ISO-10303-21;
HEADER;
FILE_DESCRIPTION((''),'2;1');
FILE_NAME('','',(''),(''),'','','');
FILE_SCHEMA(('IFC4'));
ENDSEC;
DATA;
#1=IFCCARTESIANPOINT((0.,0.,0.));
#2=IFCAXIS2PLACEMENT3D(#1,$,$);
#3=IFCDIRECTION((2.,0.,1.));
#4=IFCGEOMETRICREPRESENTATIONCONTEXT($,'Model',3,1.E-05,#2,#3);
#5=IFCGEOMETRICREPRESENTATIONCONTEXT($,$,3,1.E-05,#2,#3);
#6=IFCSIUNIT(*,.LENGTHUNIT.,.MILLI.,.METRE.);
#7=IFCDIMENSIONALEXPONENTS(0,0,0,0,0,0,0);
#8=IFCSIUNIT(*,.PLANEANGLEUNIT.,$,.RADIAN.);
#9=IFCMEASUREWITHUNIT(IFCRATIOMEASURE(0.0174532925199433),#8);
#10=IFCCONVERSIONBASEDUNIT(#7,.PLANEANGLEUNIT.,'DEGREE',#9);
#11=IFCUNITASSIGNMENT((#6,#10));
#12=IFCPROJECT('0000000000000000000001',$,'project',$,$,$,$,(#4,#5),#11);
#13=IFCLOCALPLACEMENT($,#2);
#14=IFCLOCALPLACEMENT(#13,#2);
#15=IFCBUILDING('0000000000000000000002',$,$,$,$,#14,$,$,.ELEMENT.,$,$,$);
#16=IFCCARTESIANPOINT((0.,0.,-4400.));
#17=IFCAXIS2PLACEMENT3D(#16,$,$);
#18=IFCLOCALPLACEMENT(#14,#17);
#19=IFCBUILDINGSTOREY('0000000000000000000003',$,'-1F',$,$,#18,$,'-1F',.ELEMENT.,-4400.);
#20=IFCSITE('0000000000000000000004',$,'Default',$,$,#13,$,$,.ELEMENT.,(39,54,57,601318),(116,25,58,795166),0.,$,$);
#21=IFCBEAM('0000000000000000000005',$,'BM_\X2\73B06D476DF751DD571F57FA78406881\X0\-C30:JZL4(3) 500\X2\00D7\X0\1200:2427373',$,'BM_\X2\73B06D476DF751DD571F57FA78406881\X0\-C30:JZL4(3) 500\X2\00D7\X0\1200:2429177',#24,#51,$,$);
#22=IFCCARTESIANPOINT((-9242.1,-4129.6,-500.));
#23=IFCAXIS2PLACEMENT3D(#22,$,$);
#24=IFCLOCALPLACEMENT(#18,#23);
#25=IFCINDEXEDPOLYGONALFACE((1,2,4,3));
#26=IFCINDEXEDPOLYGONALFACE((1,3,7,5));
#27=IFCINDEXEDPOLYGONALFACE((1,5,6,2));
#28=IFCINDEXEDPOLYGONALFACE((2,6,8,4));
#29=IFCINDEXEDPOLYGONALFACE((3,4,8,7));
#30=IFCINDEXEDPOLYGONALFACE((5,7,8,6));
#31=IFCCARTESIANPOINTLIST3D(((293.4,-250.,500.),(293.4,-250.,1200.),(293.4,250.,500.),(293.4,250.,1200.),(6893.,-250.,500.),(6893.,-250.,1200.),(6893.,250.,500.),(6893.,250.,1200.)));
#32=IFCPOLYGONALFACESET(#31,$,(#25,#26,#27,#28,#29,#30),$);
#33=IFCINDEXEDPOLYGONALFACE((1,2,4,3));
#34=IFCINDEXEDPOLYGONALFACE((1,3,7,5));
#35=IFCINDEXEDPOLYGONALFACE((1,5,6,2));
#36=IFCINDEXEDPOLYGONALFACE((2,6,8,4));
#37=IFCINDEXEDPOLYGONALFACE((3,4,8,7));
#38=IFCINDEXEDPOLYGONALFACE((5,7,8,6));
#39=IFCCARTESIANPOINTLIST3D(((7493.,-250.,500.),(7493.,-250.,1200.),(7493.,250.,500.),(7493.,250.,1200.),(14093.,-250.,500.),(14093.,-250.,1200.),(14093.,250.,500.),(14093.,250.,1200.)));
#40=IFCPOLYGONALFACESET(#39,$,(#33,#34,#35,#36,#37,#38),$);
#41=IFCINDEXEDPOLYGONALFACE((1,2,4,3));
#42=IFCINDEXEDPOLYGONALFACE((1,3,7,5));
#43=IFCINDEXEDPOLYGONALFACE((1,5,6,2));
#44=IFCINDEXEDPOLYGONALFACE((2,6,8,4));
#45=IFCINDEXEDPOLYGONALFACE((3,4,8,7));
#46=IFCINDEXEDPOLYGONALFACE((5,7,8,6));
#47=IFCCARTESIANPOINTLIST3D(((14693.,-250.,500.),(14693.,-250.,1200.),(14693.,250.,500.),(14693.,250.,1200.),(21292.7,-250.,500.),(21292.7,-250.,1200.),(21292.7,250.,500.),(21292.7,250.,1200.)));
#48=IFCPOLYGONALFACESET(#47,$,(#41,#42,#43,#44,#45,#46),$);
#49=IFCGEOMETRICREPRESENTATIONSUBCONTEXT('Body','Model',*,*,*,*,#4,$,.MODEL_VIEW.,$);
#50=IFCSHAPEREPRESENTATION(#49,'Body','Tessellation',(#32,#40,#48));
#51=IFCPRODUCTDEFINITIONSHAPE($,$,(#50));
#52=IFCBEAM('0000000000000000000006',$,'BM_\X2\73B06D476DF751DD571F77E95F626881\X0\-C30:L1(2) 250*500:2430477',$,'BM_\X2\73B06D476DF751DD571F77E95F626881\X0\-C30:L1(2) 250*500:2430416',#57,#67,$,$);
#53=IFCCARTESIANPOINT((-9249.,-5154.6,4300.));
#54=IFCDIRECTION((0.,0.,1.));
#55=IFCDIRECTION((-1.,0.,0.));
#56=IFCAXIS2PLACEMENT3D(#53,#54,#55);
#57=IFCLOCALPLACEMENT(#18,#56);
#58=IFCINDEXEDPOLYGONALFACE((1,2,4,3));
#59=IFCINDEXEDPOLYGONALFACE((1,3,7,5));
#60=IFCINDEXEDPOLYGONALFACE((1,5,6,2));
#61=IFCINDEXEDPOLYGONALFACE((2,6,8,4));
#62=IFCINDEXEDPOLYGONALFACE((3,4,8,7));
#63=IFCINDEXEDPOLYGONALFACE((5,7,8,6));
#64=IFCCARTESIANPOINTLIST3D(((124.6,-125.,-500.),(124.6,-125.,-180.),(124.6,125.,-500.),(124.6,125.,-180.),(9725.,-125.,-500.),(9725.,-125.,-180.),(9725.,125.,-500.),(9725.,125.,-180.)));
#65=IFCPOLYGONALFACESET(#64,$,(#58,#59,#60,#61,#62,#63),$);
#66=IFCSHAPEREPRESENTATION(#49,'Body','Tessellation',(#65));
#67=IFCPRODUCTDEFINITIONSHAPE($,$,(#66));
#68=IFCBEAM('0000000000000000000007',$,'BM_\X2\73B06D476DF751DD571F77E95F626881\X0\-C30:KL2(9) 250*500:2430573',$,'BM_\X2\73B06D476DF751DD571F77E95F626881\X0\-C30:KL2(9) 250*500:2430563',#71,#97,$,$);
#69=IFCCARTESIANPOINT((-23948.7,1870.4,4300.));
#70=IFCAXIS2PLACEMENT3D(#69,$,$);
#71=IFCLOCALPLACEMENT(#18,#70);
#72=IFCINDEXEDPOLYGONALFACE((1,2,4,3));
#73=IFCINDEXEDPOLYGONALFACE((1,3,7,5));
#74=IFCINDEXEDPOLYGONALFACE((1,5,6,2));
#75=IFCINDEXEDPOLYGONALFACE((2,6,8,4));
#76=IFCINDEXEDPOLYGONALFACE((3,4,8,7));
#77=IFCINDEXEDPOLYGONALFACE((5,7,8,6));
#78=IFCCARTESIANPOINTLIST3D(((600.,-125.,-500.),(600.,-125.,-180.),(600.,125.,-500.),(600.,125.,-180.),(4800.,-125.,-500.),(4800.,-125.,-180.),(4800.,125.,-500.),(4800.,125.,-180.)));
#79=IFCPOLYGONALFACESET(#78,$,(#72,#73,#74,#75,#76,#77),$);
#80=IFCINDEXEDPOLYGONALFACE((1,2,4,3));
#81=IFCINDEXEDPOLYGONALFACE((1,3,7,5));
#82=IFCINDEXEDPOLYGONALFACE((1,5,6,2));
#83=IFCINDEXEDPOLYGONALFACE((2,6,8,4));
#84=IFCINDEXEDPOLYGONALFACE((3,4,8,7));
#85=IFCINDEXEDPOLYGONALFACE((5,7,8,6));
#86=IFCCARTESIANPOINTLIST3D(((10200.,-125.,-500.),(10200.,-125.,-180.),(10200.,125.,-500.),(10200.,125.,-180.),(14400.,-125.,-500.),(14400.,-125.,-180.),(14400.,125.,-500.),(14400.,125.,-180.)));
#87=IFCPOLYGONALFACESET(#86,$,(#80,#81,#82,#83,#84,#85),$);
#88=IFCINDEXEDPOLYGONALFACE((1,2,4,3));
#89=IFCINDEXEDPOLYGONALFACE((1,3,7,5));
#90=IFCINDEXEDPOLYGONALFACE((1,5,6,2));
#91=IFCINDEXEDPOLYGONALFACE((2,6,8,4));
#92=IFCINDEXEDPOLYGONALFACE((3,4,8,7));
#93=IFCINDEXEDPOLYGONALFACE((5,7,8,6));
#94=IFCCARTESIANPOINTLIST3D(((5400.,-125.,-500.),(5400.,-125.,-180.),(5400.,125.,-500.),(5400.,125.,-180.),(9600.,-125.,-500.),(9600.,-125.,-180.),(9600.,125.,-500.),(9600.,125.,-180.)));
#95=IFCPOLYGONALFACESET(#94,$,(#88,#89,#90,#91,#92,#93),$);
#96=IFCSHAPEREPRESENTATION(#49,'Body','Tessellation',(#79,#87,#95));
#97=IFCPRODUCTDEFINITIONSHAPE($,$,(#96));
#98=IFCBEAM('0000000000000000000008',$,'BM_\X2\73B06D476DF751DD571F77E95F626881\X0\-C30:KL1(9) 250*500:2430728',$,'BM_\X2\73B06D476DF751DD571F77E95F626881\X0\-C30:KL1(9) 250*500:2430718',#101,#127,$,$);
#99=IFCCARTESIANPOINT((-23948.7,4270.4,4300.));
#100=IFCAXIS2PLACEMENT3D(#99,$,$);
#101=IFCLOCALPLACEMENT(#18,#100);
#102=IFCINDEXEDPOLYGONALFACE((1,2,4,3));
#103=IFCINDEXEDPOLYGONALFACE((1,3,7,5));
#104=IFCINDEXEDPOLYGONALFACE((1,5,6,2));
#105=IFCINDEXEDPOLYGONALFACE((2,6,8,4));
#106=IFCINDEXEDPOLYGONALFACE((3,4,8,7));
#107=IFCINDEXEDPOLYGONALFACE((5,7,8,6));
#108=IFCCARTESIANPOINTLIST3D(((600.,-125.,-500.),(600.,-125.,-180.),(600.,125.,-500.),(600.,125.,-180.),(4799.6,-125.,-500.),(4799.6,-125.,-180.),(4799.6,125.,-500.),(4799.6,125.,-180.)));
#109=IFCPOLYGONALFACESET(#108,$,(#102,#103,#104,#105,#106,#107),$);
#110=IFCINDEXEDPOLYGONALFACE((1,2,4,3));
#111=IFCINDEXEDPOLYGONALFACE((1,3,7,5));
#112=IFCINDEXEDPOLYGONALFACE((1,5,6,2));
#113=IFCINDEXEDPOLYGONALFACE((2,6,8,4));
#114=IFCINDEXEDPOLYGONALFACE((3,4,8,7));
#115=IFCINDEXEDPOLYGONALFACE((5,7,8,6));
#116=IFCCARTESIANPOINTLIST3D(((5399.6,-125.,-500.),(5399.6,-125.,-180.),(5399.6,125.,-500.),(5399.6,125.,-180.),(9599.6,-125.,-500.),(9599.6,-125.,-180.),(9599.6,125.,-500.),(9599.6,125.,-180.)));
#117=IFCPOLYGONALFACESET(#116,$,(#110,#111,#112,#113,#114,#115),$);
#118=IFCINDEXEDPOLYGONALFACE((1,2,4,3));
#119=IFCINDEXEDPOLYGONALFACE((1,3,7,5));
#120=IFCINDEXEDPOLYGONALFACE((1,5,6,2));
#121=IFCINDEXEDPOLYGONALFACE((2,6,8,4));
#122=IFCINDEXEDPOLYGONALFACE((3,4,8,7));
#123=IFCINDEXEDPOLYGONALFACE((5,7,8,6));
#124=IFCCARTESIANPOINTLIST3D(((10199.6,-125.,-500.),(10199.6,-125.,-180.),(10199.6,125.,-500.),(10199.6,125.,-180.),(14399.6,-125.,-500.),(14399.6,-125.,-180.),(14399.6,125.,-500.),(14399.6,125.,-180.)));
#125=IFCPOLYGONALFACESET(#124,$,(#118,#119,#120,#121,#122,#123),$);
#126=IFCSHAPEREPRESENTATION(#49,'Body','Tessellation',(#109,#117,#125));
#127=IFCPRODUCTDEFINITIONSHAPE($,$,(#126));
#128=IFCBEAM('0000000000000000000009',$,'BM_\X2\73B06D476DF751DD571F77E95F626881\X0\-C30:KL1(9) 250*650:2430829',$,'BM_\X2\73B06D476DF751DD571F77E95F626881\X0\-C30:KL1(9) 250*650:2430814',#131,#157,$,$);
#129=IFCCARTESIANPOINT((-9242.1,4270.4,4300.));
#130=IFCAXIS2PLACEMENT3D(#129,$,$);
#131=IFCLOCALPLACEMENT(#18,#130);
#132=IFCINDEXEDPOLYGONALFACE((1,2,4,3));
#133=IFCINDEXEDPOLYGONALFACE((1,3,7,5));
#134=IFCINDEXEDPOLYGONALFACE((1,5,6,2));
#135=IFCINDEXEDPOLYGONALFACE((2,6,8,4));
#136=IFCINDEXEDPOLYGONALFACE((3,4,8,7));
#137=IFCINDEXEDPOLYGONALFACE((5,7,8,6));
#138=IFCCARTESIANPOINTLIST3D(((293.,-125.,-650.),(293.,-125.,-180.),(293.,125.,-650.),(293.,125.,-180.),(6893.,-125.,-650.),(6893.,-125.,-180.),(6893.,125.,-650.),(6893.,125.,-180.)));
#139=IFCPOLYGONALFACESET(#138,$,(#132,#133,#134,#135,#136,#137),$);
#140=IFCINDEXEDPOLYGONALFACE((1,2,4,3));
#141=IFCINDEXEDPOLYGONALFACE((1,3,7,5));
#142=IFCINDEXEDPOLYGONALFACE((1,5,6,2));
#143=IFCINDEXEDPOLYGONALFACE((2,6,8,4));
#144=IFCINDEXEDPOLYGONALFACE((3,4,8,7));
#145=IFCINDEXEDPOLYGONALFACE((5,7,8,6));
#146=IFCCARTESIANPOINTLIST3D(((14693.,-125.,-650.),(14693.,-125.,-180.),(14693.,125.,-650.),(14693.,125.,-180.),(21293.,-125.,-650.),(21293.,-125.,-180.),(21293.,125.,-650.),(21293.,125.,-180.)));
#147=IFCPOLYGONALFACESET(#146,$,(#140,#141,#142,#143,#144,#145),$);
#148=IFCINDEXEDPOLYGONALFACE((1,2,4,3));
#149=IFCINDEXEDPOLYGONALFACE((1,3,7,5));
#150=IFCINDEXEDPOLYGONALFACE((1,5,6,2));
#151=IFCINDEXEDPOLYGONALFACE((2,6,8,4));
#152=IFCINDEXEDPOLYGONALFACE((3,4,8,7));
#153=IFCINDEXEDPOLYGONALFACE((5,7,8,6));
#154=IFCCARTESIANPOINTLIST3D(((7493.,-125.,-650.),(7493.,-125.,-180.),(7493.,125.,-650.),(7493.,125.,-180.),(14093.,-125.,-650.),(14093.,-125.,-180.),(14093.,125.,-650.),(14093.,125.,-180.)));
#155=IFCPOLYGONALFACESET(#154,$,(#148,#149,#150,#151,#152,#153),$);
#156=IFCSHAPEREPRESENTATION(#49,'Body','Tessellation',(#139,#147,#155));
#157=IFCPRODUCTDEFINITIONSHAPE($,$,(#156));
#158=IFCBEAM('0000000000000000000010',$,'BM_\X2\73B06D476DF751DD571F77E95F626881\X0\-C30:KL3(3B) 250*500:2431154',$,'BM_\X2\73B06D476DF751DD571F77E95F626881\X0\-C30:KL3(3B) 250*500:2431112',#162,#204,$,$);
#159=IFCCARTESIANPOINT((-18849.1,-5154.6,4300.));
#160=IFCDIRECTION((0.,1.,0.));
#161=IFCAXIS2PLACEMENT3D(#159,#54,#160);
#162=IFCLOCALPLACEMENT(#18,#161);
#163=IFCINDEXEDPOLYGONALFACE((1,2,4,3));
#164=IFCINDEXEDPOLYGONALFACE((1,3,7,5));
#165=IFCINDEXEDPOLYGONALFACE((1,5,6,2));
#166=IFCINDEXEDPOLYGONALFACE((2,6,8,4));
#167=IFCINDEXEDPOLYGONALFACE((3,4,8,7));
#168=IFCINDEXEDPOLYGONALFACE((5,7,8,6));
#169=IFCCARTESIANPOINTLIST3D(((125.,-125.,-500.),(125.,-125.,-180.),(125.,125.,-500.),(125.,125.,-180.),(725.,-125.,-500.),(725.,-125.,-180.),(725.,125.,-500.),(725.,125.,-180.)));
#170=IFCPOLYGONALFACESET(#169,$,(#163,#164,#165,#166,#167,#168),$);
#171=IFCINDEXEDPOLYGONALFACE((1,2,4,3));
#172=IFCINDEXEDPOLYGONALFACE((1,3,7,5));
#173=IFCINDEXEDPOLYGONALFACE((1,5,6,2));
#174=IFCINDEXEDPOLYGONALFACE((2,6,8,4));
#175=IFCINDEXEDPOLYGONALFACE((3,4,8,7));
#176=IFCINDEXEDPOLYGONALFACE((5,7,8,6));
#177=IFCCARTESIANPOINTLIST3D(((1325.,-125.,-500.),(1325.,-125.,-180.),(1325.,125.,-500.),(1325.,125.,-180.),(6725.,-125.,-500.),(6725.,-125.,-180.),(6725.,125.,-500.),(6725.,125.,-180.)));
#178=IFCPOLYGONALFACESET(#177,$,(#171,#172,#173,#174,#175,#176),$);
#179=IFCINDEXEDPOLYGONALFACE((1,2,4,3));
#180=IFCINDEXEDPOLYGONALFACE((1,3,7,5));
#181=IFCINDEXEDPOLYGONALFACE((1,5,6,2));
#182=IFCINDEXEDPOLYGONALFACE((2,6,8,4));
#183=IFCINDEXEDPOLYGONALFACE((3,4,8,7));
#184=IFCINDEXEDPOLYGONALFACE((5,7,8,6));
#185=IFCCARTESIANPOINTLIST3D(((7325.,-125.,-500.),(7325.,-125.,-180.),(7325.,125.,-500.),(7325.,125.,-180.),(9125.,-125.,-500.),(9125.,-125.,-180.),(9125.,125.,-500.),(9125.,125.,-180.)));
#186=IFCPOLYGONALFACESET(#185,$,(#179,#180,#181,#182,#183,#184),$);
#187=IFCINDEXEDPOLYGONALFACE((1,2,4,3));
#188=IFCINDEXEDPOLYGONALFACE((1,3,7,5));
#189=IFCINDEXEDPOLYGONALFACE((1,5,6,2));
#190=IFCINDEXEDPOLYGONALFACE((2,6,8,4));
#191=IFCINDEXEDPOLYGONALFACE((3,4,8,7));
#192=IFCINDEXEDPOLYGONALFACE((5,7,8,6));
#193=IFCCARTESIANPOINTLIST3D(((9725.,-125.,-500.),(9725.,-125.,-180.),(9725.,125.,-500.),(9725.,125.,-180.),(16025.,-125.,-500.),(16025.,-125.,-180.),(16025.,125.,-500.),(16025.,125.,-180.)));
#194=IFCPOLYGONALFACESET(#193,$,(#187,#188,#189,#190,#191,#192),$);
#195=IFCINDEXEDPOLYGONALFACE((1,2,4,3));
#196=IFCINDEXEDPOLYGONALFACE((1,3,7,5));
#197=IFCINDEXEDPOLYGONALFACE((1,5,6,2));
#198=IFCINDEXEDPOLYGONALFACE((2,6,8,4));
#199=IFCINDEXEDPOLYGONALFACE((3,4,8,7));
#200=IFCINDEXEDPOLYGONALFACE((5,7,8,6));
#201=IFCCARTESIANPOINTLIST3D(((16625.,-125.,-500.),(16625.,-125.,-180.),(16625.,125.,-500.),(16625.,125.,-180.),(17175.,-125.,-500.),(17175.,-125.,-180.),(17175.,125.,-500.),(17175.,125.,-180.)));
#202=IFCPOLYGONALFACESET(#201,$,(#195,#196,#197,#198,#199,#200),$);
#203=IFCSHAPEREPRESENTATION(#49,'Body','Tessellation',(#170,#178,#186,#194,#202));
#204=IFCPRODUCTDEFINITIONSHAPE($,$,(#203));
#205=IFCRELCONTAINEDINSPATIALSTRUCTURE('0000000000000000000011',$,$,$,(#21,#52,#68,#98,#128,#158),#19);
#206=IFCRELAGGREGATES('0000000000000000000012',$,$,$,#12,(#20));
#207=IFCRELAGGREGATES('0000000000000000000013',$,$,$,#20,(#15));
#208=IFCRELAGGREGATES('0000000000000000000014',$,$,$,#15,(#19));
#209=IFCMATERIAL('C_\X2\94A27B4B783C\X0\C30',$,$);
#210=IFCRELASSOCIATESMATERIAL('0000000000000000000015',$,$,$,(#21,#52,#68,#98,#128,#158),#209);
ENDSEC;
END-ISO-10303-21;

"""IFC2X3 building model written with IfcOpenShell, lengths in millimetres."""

from ifc_helpers import new_model, entity, si_unit, converted_unit, direction, frame, frame_2d, origin, origin_2d_with_axis, place, context, subcontext, project, spatial, rectangle, extrude, material, element, save


model = new_model("IFC2X3")

# Units and contexts
model_context = context("Model", 3, precision=1e-05, world=origin(), true_north=direction((2.0, 0.0, 1.0)))
context_of_model = context(None, 3, precision=1e-05, world=origin(), true_north=direction((2.0, 0.0, 1.0)))
body_context = subcontext(model_context, "Body", "Model", "MODEL_VIEW")
ifc_project = project(units=[si_unit("LENGTHUNIT", "METRE", prefix="MILLI"), converted_unit("PLANEANGLEUNIT", "DEGREE", entity("IfcRatioMeasure", 0.0174532925199433), si_unit("PLANEANGLEUNIT", "RADIAN"), dimensions=[0, 0, 0, 0, 0, 0, 0])], contexts=[model_context, context_of_model])

# Site, building, storey
site_placement = place(None, origin())
site = spatial("IfcSite", under=ifc_project, at=site_placement, Name="Default", CompositionType="ELEMENT", RefLatitude=(39, 54, 57, 601318), RefLongitude=(116, 25, 58, 795166), RefElevation=0.0)
building_placement = place(site_placement, origin())
building = spatial("IfcBuilding", under=site, at=building_placement, CompositionType="ELEMENT")
storey_placement = place(building_placement, frame((0.0, 0.0, -4400.0)))
storey = spatial("IfcBuildingStorey", under=building, at=storey_placement, Name="-1F", LongName="-1F", CompositionType="ELEMENT", Elevation=-4400.0)

# Beams
ifc_material_1 = material(Name="C_钢筋砼C30")
beam_1_placement = place(storey_placement, frame((-9242.1, -4129.6, -500.0)))
element("IfcBeam", 1, at=beam_1_placement, inside=storey, material=ifc_material_1, Name="BM_现浇混凝土基础梁-C30:JZL4(3) 500×1200:2427373", ObjectType="BM_现浇混凝土基础梁-C30:JZL4(3) 500×1200:2429177", context=body_context, shape_type="SweptSolid", body=[
    extrude(rectangle(XDim=700.0, YDim=500.0, at=frame_2d((0.0, 0.0), x_axis=(1.0, 0.0))), frame((293.4, 0.0, 850.0), z_axis=(1.0, 0.0, 0.0), x_axis=(0.0, 0.0, -1.0)), (0.0, 0.0, 1.0), 6599.6),
    extrude(rectangle(XDim=700.0, YDim=500.0, at=origin_2d_with_axis()), frame((7493.0, 0.0, 850.0), z_axis=(1.0, 0.0, 0.0), x_axis=(0.0, 0.0, -1.0)), (0.0, 0.0, 1.0), 6600.0),
    extrude(rectangle(XDim=700.0, YDim=500.0, at=frame_2d((0.0, 0.0), x_axis=(1.0, 0.0))), frame((14693.0, 0.0, 850.0), z_axis=(1.0, 0.0, 0.0), x_axis=(0.0, 0.0, -1.0)), (0.0, 0.0, 1.0), 6599.6),
])
beam_2_placement = place(storey_placement, frame((-9249.0, -5154.6, 4300.0), z_axis=(0.0, 0.0, 1.0), x_axis=(-1.0, 0.0, 0.0)))
element("IfcBeam", 2, at=beam_2_placement, inside=storey, material=ifc_material_1, Name="BM_现浇混凝土矩形梁-C30:L1(2) 250*500:2430477", ObjectType="BM_现浇混凝土矩形梁-C30:L1(2) 250*500:2430416", context=body_context, shape_type="SweptSolid", body=[
    extrude(rectangle(XDim=320.0, YDim=250.0, at=frame_2d((0.0, 0.0), x_axis=(1.0, 0.0))), frame((124.6, 0.0, -340.0), z_axis=(1.0, 0.0, 0.0), x_axis=(0.0, 0.0, -1.0)), (0.0, 0.0, 1.0), 9600.4),
])
beam_3_placement = place(storey_placement, frame((-23948.7, 1870.4, 4300.0)))
element("IfcBeam", 3, at=beam_3_placement, inside=storey, material=ifc_material_1, Name="BM_现浇混凝土矩形梁-C30:KL2(9) 250*500:2430573", ObjectType="BM_现浇混凝土矩形梁-C30:KL2(9) 250*500:2430563", context=body_context, shape_type="SweptSolid", body=[
    extrude(rectangle(XDim=320.0, YDim=250.0, at=frame_2d((0.0, 0.0), x_axis=(1.0, 0.0))), frame((600.0, 0.0, -340.0), z_axis=(1.0, 0.0, 0.0), x_axis=(0.0, 0.0, 1.0)), (0.0, 0.0, 1.0), 4200.0),
    extrude(rectangle(XDim=320.0, YDim=250.0, at=origin_2d_with_axis()), frame((10200.0, 0.0, -340.0), z_axis=(1.0, 0.0, 0.0), x_axis=(0.0, 0.0, 1.0)), (0.0, 0.0, 1.0), 4200.0),
    extrude(rectangle(XDim=320.0, YDim=250.0, at=origin_2d_with_axis()), frame((5400.0, 0.0, -340.0), z_axis=(1.0, 0.0, 0.0), x_axis=(0.0, 0.0, 1.0)), (0.0, 0.0, 1.0), 4200.0),
])
beam_4_placement = place(storey_placement, frame((-23948.7, 4270.4, 4300.0)))
element("IfcBeam", 4, at=beam_4_placement, inside=storey, material=ifc_material_1, Name="BM_现浇混凝土矩形梁-C30:KL1(9) 250*500:2430728", ObjectType="BM_现浇混凝土矩形梁-C30:KL1(9) 250*500:2430718", context=body_context, shape_type="SweptSolid", body=[
    extrude(rectangle(XDim=320.0, YDim=250.0, at=frame_2d((0.0, 0.0), x_axis=(1.0, 0.0))), frame((600.0, 0.0, -340.0), z_axis=(1.0, 0.0, 0.0), x_axis=(0.0, 0.0, 1.0)), (0.0, 0.0, 1.0), 4199.6),
    extrude(rectangle(XDim=320.0, YDim=250.0, at=frame_2d((0.0, 0.0), x_axis=(1.0, 0.0))), frame((5399.6, 0.0, -340.0), z_axis=(1.0, 0.0, 0.0), x_axis=(0.0, 0.0, 1.0)), (0.0, 0.0, 1.0), 4200.0),
    extrude(rectangle(XDim=320.0, YDim=250.0, at=frame_2d((0.0, 0.0), x_axis=(1.0, 0.0))), frame((10199.6, 0.0, -340.0), z_axis=(1.0, 0.0, 0.0), x_axis=(0.0, 0.0, 1.0)), (0.0, 0.0, 1.0), 4200.0),
])
beam_5_placement = place(storey_placement, frame((-9242.1, 4270.4, 4300.0)))
element("IfcBeam", 5, at=beam_5_placement, inside=storey, material=ifc_material_1, Name="BM_现浇混凝土矩形梁-C30:KL1(9) 250*650:2430829", ObjectType="BM_现浇混凝土矩形梁-C30:KL1(9) 250*650:2430814", context=body_context, shape_type="SweptSolid", body=[
    extrude(rectangle(XDim=470.0, YDim=250.0, at=origin_2d_with_axis()), frame((293.0, 0.0, -415.0), z_axis=(1.0, 0.0, 0.0), x_axis=(0.0, 0.0, 1.0)), (0.0, 0.0, 1.0), 6600.0),
    extrude(rectangle(XDim=470.0, YDim=250.0, at=frame_2d((-37.0, 25.0), x_axis=(1.0, 0.0))), frame((14693.0, 25.0, -378.0), z_axis=(1.0, 0.0, 0.0), x_axis=(0.0, 0.0, 1.0)), (0.0, 0.0, 1.0), 6600.0),
    extrude(rectangle(XDim=470.0, YDim=250.0, at=origin_2d_with_axis()), frame((7493.0, 0.0, -415.0), z_axis=(1.0, 0.0, 0.0), x_axis=(0.0, 0.0, 1.0)), (0.0, 0.0, 1.0), 6600.0),
])
beam_6_placement = place(storey_placement, frame((-18849.1, -5154.6, 4300.0), z_axis=(0.0, 0.0, 1.0), x_axis=(0.0, 1.0, 0.0)))
element("IfcBeam", 6, at=beam_6_placement, inside=storey, material=ifc_material_1, Name="BM_现浇混凝土矩形梁-C30:KL3(3B) 250*500:2431154", ObjectType="BM_现浇混凝土矩形梁-C30:KL3(3B) 250*500:2431112", context=body_context, shape_type="SweptSolid", body=[
    extrude(rectangle(XDim=320.0, YDim=250.0, at=origin_2d_with_axis()), frame((125.0, 0.0, -340.0), z_axis=(1.0, 0.0, 0.0), x_axis=(0.0, 0.0, 1.0)), (0.0, 0.0, 1.0), 600.0),
    extrude(rectangle(XDim=320.0, YDim=250.0, at=origin_2d_with_axis()), frame((1325.0, 0.0, -340.0), z_axis=(1.0, 0.0, 0.0), x_axis=(0.0, 0.0, 1.0)), (0.0, 0.0, 1.0), 5400.0),
    extrude(rectangle(XDim=320.0, YDim=250.0, at=frame_2d((0.0, 0.0), x_axis=(1.0, 0.0))), frame((7325.0, 0.0, -340.0), z_axis=(1.0, 0.0, 0.0), x_axis=(0.0, 0.0, 1.0)), (0.0, 0.0, 1.0), 1800.0),
    extrude(rectangle(XDim=320.0, YDim=250.0, at=origin_2d_with_axis()), frame((9725.0, 0.0, -340.0), z_axis=(1.0, 0.0, 0.0), x_axis=(0.0, 0.0, 1.0)), (0.0, 0.0, 1.0), 6300.0),
    extrude(rectangle(XDim=320.0, YDim=250.0, at=origin_2d_with_axis()), frame((16625.0, 0.0, -340.0), z_axis=(1.0, 0.0, 0.0), x_axis=(0.0, 0.0, 1.0)), (0.0, 0.0, 1.0), 550.0),
])

save(model, "model.ifc")
